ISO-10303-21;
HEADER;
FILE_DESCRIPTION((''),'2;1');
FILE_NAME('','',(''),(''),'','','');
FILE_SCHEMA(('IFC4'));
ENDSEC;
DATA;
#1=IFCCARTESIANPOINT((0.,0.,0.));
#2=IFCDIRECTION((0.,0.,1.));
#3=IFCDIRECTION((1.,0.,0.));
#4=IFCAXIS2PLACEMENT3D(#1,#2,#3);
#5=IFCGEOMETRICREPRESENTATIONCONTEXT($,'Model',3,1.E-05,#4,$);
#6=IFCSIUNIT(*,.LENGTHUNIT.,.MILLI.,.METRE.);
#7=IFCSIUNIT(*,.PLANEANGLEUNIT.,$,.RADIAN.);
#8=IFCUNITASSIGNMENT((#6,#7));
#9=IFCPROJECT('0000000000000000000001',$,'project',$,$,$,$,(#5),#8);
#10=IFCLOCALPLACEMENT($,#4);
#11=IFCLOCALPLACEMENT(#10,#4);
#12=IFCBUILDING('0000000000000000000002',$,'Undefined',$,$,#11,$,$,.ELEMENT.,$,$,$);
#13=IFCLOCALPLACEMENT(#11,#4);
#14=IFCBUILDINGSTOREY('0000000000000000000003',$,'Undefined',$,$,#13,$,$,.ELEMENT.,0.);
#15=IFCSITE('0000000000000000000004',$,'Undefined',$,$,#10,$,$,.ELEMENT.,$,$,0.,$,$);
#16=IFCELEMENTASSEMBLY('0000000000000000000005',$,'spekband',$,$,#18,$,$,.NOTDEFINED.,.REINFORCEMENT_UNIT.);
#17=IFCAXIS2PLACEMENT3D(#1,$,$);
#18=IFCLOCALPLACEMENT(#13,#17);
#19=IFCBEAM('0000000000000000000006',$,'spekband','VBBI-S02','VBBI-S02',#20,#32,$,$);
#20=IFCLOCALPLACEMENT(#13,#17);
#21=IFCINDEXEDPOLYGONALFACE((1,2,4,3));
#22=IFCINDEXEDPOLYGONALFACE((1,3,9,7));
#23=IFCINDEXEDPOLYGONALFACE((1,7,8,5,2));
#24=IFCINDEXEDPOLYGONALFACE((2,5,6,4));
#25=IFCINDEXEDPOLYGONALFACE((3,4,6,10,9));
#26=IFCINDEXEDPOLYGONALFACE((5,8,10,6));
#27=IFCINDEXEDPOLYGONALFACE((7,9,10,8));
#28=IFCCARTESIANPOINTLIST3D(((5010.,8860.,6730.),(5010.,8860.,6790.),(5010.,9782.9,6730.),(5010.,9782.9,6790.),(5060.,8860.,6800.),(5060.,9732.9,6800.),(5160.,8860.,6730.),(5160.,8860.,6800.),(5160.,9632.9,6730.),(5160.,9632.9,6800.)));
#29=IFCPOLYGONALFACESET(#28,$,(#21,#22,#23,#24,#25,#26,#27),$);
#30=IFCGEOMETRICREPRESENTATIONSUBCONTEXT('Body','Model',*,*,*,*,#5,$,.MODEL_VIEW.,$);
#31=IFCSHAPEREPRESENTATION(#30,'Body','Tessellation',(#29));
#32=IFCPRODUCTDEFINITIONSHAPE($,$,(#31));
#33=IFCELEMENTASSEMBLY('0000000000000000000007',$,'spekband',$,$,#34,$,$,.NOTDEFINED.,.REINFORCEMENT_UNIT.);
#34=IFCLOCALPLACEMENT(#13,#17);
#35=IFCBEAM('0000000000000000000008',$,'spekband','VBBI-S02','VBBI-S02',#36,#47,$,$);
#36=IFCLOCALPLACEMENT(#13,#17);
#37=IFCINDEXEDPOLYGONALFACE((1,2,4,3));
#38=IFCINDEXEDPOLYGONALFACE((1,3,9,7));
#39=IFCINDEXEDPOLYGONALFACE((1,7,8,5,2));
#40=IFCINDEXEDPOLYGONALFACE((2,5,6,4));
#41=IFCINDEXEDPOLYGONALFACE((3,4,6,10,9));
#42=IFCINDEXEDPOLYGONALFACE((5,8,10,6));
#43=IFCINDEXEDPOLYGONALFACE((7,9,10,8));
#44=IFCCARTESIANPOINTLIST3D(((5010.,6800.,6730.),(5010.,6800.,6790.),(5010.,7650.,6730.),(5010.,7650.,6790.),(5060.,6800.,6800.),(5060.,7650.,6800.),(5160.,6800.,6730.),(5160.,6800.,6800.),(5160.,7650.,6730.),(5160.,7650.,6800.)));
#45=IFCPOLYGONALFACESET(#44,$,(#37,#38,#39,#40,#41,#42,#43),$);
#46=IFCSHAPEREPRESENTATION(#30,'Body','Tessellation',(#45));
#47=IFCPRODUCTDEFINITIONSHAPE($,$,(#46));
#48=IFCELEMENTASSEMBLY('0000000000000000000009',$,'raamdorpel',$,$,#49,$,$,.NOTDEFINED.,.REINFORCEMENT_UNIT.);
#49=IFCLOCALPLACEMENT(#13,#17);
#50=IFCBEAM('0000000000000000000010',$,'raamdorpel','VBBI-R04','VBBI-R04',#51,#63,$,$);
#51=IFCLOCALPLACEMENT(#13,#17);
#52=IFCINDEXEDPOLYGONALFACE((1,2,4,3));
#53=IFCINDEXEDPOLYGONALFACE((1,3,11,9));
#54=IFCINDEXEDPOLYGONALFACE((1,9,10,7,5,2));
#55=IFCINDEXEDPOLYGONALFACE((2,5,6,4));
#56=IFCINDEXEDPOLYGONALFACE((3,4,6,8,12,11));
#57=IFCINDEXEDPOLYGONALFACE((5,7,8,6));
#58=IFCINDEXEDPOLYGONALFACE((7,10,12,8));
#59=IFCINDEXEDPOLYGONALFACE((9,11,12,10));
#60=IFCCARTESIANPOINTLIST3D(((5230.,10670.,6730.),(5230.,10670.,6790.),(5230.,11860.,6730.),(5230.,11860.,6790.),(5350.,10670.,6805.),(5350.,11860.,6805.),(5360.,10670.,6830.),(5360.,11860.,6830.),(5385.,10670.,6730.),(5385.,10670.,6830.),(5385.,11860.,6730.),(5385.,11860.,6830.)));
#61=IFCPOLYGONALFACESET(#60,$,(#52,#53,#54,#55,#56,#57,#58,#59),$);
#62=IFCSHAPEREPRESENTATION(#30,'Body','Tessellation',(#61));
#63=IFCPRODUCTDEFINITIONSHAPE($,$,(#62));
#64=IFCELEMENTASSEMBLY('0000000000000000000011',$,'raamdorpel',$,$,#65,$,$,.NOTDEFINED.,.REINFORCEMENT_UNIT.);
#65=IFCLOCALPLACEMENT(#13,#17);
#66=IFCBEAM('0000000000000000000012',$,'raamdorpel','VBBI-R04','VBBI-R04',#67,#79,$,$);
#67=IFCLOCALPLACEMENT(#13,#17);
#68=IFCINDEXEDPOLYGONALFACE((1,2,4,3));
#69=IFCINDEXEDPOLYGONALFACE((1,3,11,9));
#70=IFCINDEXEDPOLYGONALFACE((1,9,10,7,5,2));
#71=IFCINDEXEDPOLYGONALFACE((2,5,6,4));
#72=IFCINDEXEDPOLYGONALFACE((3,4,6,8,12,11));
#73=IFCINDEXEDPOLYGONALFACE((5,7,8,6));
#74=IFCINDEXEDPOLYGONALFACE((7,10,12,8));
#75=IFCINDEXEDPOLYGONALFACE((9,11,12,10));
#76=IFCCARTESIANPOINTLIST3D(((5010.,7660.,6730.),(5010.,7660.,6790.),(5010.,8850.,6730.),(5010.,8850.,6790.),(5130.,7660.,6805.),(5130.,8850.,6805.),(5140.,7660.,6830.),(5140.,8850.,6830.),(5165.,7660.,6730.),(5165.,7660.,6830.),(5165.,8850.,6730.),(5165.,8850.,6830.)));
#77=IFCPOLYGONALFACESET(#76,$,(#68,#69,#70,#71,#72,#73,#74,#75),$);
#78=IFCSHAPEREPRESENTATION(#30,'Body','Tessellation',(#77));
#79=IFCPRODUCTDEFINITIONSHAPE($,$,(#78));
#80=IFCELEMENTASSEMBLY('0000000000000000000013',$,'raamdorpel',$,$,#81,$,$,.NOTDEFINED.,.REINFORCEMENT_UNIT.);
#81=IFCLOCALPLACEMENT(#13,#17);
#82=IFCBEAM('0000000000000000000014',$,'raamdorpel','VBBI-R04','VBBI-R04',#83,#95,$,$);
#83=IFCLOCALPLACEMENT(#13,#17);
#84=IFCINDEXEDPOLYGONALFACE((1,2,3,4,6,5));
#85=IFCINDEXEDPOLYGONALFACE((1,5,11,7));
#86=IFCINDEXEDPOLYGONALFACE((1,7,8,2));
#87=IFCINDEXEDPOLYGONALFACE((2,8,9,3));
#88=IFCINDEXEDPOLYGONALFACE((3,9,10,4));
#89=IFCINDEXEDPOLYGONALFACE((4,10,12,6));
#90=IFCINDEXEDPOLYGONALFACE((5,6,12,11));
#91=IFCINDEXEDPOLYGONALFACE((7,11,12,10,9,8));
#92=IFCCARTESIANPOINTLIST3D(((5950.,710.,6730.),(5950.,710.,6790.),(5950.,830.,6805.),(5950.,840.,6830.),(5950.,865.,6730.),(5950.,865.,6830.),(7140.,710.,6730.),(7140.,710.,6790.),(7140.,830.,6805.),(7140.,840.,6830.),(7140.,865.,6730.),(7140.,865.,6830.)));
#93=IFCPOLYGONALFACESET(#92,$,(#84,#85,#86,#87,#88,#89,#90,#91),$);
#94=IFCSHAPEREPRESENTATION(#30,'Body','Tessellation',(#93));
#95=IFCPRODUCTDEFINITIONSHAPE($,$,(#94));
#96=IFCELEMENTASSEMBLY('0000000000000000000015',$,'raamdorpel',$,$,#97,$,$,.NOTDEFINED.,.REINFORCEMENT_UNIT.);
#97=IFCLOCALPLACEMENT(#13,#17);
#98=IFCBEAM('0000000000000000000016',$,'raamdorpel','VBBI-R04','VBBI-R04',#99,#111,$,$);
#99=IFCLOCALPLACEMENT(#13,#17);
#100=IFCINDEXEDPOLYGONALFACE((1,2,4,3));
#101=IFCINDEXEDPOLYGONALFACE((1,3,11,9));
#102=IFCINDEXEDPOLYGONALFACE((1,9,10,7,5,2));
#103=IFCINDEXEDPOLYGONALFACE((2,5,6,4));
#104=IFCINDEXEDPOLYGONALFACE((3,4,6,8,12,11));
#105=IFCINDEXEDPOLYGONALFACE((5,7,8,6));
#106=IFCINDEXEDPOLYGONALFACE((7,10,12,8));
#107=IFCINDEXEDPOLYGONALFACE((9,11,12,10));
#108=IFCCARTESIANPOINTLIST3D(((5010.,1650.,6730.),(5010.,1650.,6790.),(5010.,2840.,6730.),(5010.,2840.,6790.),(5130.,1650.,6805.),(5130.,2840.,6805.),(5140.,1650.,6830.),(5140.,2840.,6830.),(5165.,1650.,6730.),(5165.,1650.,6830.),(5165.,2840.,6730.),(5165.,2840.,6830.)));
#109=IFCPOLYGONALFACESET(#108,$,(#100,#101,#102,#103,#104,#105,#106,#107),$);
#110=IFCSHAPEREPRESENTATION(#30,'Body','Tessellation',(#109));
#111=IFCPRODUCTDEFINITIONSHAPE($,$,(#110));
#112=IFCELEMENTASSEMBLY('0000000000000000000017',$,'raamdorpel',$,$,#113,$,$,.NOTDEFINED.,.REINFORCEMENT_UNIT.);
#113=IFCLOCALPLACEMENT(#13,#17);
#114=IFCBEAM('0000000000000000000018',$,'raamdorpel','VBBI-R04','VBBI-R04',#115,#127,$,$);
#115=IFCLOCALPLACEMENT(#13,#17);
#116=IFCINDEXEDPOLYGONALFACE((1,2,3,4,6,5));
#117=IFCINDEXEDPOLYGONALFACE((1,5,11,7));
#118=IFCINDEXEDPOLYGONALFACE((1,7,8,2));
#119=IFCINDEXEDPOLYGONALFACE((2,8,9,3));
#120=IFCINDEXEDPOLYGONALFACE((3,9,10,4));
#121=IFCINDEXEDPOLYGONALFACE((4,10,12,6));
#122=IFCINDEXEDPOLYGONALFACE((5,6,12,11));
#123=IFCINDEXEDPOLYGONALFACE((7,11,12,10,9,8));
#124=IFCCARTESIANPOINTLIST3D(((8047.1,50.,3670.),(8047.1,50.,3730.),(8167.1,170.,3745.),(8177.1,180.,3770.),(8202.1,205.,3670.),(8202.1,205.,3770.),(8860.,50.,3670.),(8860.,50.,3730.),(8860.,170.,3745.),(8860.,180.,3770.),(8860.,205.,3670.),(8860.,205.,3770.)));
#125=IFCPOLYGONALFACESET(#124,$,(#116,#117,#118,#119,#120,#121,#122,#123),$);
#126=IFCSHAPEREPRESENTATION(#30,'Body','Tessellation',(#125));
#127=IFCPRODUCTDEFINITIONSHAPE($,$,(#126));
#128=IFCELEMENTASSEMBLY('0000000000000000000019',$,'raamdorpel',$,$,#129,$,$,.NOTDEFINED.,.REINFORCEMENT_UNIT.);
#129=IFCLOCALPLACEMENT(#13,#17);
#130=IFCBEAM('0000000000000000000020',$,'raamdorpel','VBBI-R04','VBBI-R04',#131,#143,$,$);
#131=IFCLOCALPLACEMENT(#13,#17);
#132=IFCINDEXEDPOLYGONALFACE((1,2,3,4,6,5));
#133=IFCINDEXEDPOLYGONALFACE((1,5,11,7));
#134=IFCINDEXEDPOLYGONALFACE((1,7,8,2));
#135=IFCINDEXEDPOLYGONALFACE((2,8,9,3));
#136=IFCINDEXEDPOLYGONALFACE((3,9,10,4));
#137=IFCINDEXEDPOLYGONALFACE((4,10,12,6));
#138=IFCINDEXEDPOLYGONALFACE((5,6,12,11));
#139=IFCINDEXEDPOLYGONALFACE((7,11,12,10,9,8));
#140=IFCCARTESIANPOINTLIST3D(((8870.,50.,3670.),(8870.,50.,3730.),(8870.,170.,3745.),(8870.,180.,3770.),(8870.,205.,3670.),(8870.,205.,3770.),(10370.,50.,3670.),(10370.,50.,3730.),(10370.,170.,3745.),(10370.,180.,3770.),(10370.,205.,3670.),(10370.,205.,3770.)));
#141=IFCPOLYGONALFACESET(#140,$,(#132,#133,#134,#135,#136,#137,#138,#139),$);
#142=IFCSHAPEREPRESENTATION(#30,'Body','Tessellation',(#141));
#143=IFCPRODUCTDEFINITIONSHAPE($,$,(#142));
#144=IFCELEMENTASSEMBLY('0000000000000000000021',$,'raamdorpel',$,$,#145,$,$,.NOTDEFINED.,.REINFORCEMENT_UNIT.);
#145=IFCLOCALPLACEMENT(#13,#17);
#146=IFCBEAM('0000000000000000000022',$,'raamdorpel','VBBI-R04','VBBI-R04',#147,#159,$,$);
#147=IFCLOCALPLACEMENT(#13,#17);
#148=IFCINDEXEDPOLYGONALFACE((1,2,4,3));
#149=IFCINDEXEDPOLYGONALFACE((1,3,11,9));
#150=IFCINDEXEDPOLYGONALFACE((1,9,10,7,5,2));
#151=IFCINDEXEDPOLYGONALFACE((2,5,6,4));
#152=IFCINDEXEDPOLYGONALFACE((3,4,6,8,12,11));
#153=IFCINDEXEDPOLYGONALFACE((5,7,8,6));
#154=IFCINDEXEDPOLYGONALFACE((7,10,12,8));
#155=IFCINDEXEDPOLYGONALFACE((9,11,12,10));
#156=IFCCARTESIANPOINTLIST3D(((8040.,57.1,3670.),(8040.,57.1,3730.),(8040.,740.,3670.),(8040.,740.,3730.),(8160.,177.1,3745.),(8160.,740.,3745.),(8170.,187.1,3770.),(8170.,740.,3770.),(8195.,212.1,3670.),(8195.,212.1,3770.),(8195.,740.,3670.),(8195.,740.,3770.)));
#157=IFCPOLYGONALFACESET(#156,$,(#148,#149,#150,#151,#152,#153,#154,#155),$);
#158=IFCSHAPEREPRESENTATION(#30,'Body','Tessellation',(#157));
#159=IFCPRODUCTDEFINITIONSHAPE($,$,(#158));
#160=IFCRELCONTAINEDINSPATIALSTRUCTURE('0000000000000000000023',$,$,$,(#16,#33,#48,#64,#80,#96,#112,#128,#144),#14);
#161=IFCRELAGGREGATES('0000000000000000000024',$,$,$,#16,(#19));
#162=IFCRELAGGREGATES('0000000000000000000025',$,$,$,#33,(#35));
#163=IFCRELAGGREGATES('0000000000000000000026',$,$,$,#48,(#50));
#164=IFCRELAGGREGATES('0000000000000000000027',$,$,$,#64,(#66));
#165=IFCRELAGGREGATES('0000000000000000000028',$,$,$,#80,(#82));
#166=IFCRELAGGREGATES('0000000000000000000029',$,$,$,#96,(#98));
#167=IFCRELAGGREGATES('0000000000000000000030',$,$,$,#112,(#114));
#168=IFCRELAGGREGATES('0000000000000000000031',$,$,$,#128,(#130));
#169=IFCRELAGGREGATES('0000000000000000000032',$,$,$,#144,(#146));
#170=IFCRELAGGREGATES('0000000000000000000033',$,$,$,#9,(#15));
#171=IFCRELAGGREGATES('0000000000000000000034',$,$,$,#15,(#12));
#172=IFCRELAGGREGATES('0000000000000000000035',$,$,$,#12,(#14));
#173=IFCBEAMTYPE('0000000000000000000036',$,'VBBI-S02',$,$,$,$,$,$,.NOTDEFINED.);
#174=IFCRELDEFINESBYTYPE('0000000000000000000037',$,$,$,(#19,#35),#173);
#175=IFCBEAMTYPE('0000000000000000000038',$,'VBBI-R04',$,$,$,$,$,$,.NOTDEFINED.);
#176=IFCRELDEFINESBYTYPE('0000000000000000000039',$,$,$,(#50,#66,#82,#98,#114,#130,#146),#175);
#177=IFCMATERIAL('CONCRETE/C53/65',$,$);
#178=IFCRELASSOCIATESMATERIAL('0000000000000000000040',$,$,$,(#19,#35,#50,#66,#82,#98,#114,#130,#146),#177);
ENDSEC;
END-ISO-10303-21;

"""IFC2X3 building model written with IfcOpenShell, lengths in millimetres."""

from ifc_helpers import new_model, si_unit, frame, origin_with_axes, place, context, subcontext, project, spatial, polyline, outline, extrude, clip, halfspace, material, type_object, element, aggregate, save


model = new_model("IFC2X3")

# Units and contexts
model_context = context("Model", 3, precision=1e-05, world=origin_with_axes())
body_context = subcontext(model_context, "Body", "Model", "MODEL_VIEW")
ifc_project = project(units=[si_unit("LENGTHUNIT", "METRE", prefix="MILLI"), si_unit("PLANEANGLEUNIT", "RADIAN")], contexts=[model_context])

# Site, building, storey
site_placement = place(None, origin_with_axes())
site = spatial("IfcSite", under=ifc_project, at=site_placement, Name="Undefined", CompositionType="ELEMENT", RefElevation=0.0)
building_placement = place(site_placement, origin_with_axes())
building = spatial("IfcBuilding", under=site, at=building_placement, Name="Undefined", CompositionType="ELEMENT")
storey_placement = place(building_placement, origin_with_axes())
storey = spatial("IfcBuildingStorey", under=building, at=storey_placement, Name="Undefined", CompositionType="ELEMENT", Elevation=0.0)

# Element assemblies, beams
ifc_material = material(Name="CONCRETE/C53/65")
beam_type_1 = type_object("IfcBeamType", Name="VBBI-S02", PredefinedType="NOTDEFINED")
assembly_1_placement = place(storey_placement, origin_with_axes())
assembly_1 = element("IfcElementAssembly", 1, at=assembly_1_placement, inside=storey, Name="spekband", AssemblyPlace="NOTDEFINED", PredefinedType="REINFORCEMENT_UNIT")
beam_1_placement = place(assembly_1_placement, frame((5085.0, 9790.0, 6765.0), z_axis=(-1.0, 0.0, 0.0), x_axis=(0.0, -1.0, 0.0)))
beam_1 = element("IfcBeam", 2, at=beam_1_placement, type_object=beam_type_1, material=ifc_material, Name="spekband", Description="VBBI-S02", ObjectType="VBBI-S02", context=body_context, shape_type="Clipping", body=[
    clip(extrude(outline(polyline([(35.0, -75.0), (-35.0, -75.0), (-35.0, 25.0), (-25.0, 75.0), (35.0, 75.0), (35.0, -75.0)])), frame((930.0, 0.0, 0.0), z_axis=(-1.0, 0.0, 0.0), x_axis=(0.0, -1.0, 0.0)), (0.0, 0.0, 1.0), 923.7), halfspace(frame((3.5, 0.0, 78.5), z_axis=(0.707107, 0.0, 0.707107), x_axis=(0.0, 1.0, 0.0)), True)),
])
aggregate(assembly_1, [beam_1])
assembly_2_placement = place(storey_placement, origin_with_axes())
assembly_2 = element("IfcElementAssembly", 3, at=assembly_2_placement, inside=storey, Name="spekband", AssemblyPlace="NOTDEFINED", PredefinedType="REINFORCEMENT_UNIT")
beam_2_placement = place(assembly_2_placement, frame((5085.0, 7650.0, 6765.0), z_axis=(-1.0, 0.0, 0.0), x_axis=(0.0, -1.0, 0.0)))
beam_2 = element("IfcBeam", 4, at=beam_2_placement, type_object=beam_type_1, material=ifc_material, Name="spekband", Description="VBBI-S02", ObjectType="VBBI-S02", context=body_context, shape_type="SweptSolid", body=[
    extrude(outline(polyline([(35.0, -75.0), (-35.0, -75.0), (-35.0, 25.0), (-25.0, 75.0), (35.0, 75.0), (35.0, -75.0)])), frame((850.0, 0.0, 0.0), z_axis=(-1.0, 0.0, 0.0), x_axis=(0.0, -1.0, 0.0)), (0.0, 0.0, 1.0), 850.0),
])
aggregate(assembly_2, [beam_2])
assembly_3_placement = place(storey_placement, origin_with_axes())
assembly_3 = element("IfcElementAssembly", 5, at=assembly_3_placement, inside=storey, Name="raamdorpel", AssemblyPlace="NOTDEFINED", PredefinedType="REINFORCEMENT_UNIT")
beam_type_2 = type_object("IfcBeamType", Name="VBBI-R04", PredefinedType="NOTDEFINED")
beam_3_placement = place(assembly_3_placement, frame((5307.5, 11860.0, 6780.0), z_axis=(-1.0, 0.0, 0.0), x_axis=(0.0, -1.0, 0.0)))
beam_3 = element("IfcBeam", 6, at=beam_3_placement, type_object=beam_type_2, material=ifc_material, Name="raamdorpel", Description="VBBI-R04", ObjectType="VBBI-R04", context=body_context, shape_type="SweptSolid", body=[
    extrude(outline(polyline([(50.0, -77.5), (-50.0, -77.5), (-50.0, -52.5), (-25.0, -42.5), (-10.0, 77.5), (50.0, 77.5), (50.0, -77.5)])), frame((1190.0, 0.0, 0.0), z_axis=(-1.0, 0.0, 0.0), x_axis=(0.0, -1.0, 0.0)), (0.0, 0.0, 1.0), 1190.0),
])
aggregate(assembly_3, [beam_3])
assembly_4_placement = place(storey_placement, origin_with_axes())
assembly_4 = element("IfcElementAssembly", 7, at=assembly_4_placement, inside=storey, Name="raamdorpel", AssemblyPlace="NOTDEFINED", PredefinedType="REINFORCEMENT_UNIT")
beam_4_placement = place(assembly_4_placement, frame((5087.5, 8850.0, 6780.0), z_axis=(-1.0, 0.0, 0.0), x_axis=(0.0, -1.0, 0.0)))
beam_4 = element("IfcBeam", 8, at=beam_4_placement, type_object=beam_type_2, material=ifc_material, Name="raamdorpel", Description="VBBI-R04", ObjectType="VBBI-R04", context=body_context, shape_type="SweptSolid", body=[
    extrude(outline(polyline([(50.0, -77.5), (-50.0, -77.5), (-50.0, -52.5), (-25.0, -42.5), (-10.0, 77.5), (50.0, 77.5), (50.0, -77.5)])), frame((1190.0, 0.0, 0.0), z_axis=(-1.0, 0.0, 0.0), x_axis=(0.0, -1.0, 0.0)), (0.0, 0.0, 1.0), 1190.0),
])
aggregate(assembly_4, [beam_4])
assembly_5_placement = place(storey_placement, origin_with_axes())
assembly_5 = element("IfcElementAssembly", 9, at=assembly_5_placement, inside=storey, Name="raamdorpel", AssemblyPlace="NOTDEFINED", PredefinedType="REINFORCEMENT_UNIT")
beam_5_placement = place(assembly_5_placement, frame((5950.0, 787.5, 6780.0), z_axis=(0.0, -1.0, 0.0), x_axis=(1.0, 0.0, 0.0)))
beam_5 = element("IfcBeam", 10, at=beam_5_placement, type_object=beam_type_2, material=ifc_material, Name="raamdorpel", Description="VBBI-R04", ObjectType="VBBI-R04", context=body_context, shape_type="SweptSolid", body=[
    extrude(outline(polyline([(50.0, -77.5), (-50.0, -77.5), (-50.0, -52.5), (-25.0, -42.5), (-10.0, 77.5), (50.0, 77.5), (50.0, -77.5)])), frame((1190.0, 0.0, 0.0), z_axis=(-1.0, 0.0, 0.0), x_axis=(0.0, -1.0, 0.0)), (0.0, 0.0, 1.0), 1190.0),
])
aggregate(assembly_5, [beam_5])
assembly_6_placement = place(storey_placement, origin_with_axes())
assembly_6 = element("IfcElementAssembly", 11, at=assembly_6_placement, inside=storey, Name="raamdorpel", AssemblyPlace="NOTDEFINED", PredefinedType="REINFORCEMENT_UNIT")
beam_6_placement = place(assembly_6_placement, frame((5087.5, 2840.0, 6780.0), z_axis=(-1.0, 0.0, 0.0), x_axis=(0.0, -1.0, 0.0)))
beam_6 = element("IfcBeam", 12, at=beam_6_placement, type_object=beam_type_2, material=ifc_material, Name="raamdorpel", Description="VBBI-R04", ObjectType="VBBI-R04", context=body_context, shape_type="SweptSolid", body=[
    extrude(outline(polyline([(50.0, -77.5), (-50.0, -77.5), (-50.0, -52.5), (-25.0, -42.5), (-10.0, 77.5), (50.0, 77.5), (50.0, -77.5)])), frame((1190.0, 0.0, 0.0), z_axis=(-1.0, 0.0, 0.0), x_axis=(0.0, -1.0, 0.0)), (0.0, 0.0, 1.0), 1190.0),
])
aggregate(assembly_6, [beam_6])
assembly_7_placement = place(storey_placement, origin_with_axes())
assembly_7 = element("IfcElementAssembly", 13, at=assembly_7_placement, inside=storey, Name="raamdorpel", AssemblyPlace="NOTDEFINED", PredefinedType="REINFORCEMENT_UNIT")
beam_7_placement = place(assembly_7_placement, frame((8040.0, 127.5, 3720.0), z_axis=(0.0, -1.0, 0.0), x_axis=(1.0, 0.0, 0.0)))
beam_7 = element("IfcBeam", 14, at=beam_7_placement, type_object=beam_type_2, material=ifc_material, Name="raamdorpel", Description="VBBI-R04", ObjectType="VBBI-R04", context=body_context, shape_type="Clipping", body=[
    clip(extrude(outline(polyline([(50.0, -77.5), (-50.0, -77.5), (-50.0, -52.5), (-25.0, -42.5), (-10.0, 77.5), (50.0, 77.5), (50.0, -77.5)])), frame((820.0, 0.0, 0.0), z_axis=(-1.0, 0.0, 0.0), x_axis=(0.0, -1.0, 0.0)), (0.0, 0.0, 1.0), 813.7), halfspace(frame((3.5, 0.0, 81.0), z_axis=(0.707107, 0.0, 0.707106), x_axis=(0.0, 1.0, 0.0)), True)),
])
aggregate(assembly_7, [beam_7])
assembly_8_placement = place(storey_placement, origin_with_axes())
assembly_8 = element("IfcElementAssembly", 15, at=assembly_8_placement, inside=storey, Name="raamdorpel", AssemblyPlace="NOTDEFINED", PredefinedType="REINFORCEMENT_UNIT")
beam_8_placement = place(assembly_8_placement, frame((8870.0, 127.5, 3720.0), z_axis=(0.0, -1.0, 0.0), x_axis=(1.0, 0.0, 0.0)))
beam_8 = element("IfcBeam", 16, at=beam_8_placement, type_object=beam_type_2, material=ifc_material, Name="raamdorpel", Description="VBBI-R04", ObjectType="VBBI-R04", context=body_context, shape_type="SweptSolid", body=[
    extrude(outline(polyline([(50.0, -77.5), (-50.0, -77.5), (-50.0, -52.5), (-25.0, -42.5), (-10.0, 77.5), (50.0, 77.5), (50.0, -77.5)])), frame((1500.0, 0.0, 0.0), z_axis=(-1.0, 0.0, 0.0), x_axis=(0.0, -1.0, 0.0)), (0.0, 0.0, 1.0), 1500.0),
])
aggregate(assembly_8, [beam_8])
assembly_9_placement = place(storey_placement, origin_with_axes())
assembly_9 = element("IfcElementAssembly", 17, at=assembly_9_placement, inside=storey, Name="raamdorpel", AssemblyPlace="NOTDEFINED", PredefinedType="REINFORCEMENT_UNIT")
beam_9_placement = place(assembly_9_placement, frame((8117.5, 740.0, 3720.0), z_axis=(-1.0, -0.000004, 0.0), x_axis=(0.000003, -1.0, 0.0)))
beam_9 = element("IfcBeam", 18, at=beam_9_placement, type_object=beam_type_2, material=ifc_material, Name="raamdorpel", Description="VBBI-R04", ObjectType="VBBI-R04", context=body_context, shape_type="Clipping", body=[
    clip(extrude(outline(polyline([(50.0, -77.5), (-50.0, -77.5), (-50.0, -52.5), (-25.0, -42.5), (-10.0, 77.5), (50.0, 77.5), (50.0, -77.5)])), frame((683.7, 0.0, 0.0), z_axis=(-1.0, 0.0, 0.0), x_axis=(0.0, -1.0, 0.0)), (0.0, 0.0, 1.0), 683.7), halfspace(frame((686.5, 0.0, 81.0), z_axis=(0.707108, 0.0, -0.707106), x_axis=(0.0, 1.0, 0.0)), False)),
])
aggregate(assembly_9, [beam_9])

save(model, "model.ifc")
